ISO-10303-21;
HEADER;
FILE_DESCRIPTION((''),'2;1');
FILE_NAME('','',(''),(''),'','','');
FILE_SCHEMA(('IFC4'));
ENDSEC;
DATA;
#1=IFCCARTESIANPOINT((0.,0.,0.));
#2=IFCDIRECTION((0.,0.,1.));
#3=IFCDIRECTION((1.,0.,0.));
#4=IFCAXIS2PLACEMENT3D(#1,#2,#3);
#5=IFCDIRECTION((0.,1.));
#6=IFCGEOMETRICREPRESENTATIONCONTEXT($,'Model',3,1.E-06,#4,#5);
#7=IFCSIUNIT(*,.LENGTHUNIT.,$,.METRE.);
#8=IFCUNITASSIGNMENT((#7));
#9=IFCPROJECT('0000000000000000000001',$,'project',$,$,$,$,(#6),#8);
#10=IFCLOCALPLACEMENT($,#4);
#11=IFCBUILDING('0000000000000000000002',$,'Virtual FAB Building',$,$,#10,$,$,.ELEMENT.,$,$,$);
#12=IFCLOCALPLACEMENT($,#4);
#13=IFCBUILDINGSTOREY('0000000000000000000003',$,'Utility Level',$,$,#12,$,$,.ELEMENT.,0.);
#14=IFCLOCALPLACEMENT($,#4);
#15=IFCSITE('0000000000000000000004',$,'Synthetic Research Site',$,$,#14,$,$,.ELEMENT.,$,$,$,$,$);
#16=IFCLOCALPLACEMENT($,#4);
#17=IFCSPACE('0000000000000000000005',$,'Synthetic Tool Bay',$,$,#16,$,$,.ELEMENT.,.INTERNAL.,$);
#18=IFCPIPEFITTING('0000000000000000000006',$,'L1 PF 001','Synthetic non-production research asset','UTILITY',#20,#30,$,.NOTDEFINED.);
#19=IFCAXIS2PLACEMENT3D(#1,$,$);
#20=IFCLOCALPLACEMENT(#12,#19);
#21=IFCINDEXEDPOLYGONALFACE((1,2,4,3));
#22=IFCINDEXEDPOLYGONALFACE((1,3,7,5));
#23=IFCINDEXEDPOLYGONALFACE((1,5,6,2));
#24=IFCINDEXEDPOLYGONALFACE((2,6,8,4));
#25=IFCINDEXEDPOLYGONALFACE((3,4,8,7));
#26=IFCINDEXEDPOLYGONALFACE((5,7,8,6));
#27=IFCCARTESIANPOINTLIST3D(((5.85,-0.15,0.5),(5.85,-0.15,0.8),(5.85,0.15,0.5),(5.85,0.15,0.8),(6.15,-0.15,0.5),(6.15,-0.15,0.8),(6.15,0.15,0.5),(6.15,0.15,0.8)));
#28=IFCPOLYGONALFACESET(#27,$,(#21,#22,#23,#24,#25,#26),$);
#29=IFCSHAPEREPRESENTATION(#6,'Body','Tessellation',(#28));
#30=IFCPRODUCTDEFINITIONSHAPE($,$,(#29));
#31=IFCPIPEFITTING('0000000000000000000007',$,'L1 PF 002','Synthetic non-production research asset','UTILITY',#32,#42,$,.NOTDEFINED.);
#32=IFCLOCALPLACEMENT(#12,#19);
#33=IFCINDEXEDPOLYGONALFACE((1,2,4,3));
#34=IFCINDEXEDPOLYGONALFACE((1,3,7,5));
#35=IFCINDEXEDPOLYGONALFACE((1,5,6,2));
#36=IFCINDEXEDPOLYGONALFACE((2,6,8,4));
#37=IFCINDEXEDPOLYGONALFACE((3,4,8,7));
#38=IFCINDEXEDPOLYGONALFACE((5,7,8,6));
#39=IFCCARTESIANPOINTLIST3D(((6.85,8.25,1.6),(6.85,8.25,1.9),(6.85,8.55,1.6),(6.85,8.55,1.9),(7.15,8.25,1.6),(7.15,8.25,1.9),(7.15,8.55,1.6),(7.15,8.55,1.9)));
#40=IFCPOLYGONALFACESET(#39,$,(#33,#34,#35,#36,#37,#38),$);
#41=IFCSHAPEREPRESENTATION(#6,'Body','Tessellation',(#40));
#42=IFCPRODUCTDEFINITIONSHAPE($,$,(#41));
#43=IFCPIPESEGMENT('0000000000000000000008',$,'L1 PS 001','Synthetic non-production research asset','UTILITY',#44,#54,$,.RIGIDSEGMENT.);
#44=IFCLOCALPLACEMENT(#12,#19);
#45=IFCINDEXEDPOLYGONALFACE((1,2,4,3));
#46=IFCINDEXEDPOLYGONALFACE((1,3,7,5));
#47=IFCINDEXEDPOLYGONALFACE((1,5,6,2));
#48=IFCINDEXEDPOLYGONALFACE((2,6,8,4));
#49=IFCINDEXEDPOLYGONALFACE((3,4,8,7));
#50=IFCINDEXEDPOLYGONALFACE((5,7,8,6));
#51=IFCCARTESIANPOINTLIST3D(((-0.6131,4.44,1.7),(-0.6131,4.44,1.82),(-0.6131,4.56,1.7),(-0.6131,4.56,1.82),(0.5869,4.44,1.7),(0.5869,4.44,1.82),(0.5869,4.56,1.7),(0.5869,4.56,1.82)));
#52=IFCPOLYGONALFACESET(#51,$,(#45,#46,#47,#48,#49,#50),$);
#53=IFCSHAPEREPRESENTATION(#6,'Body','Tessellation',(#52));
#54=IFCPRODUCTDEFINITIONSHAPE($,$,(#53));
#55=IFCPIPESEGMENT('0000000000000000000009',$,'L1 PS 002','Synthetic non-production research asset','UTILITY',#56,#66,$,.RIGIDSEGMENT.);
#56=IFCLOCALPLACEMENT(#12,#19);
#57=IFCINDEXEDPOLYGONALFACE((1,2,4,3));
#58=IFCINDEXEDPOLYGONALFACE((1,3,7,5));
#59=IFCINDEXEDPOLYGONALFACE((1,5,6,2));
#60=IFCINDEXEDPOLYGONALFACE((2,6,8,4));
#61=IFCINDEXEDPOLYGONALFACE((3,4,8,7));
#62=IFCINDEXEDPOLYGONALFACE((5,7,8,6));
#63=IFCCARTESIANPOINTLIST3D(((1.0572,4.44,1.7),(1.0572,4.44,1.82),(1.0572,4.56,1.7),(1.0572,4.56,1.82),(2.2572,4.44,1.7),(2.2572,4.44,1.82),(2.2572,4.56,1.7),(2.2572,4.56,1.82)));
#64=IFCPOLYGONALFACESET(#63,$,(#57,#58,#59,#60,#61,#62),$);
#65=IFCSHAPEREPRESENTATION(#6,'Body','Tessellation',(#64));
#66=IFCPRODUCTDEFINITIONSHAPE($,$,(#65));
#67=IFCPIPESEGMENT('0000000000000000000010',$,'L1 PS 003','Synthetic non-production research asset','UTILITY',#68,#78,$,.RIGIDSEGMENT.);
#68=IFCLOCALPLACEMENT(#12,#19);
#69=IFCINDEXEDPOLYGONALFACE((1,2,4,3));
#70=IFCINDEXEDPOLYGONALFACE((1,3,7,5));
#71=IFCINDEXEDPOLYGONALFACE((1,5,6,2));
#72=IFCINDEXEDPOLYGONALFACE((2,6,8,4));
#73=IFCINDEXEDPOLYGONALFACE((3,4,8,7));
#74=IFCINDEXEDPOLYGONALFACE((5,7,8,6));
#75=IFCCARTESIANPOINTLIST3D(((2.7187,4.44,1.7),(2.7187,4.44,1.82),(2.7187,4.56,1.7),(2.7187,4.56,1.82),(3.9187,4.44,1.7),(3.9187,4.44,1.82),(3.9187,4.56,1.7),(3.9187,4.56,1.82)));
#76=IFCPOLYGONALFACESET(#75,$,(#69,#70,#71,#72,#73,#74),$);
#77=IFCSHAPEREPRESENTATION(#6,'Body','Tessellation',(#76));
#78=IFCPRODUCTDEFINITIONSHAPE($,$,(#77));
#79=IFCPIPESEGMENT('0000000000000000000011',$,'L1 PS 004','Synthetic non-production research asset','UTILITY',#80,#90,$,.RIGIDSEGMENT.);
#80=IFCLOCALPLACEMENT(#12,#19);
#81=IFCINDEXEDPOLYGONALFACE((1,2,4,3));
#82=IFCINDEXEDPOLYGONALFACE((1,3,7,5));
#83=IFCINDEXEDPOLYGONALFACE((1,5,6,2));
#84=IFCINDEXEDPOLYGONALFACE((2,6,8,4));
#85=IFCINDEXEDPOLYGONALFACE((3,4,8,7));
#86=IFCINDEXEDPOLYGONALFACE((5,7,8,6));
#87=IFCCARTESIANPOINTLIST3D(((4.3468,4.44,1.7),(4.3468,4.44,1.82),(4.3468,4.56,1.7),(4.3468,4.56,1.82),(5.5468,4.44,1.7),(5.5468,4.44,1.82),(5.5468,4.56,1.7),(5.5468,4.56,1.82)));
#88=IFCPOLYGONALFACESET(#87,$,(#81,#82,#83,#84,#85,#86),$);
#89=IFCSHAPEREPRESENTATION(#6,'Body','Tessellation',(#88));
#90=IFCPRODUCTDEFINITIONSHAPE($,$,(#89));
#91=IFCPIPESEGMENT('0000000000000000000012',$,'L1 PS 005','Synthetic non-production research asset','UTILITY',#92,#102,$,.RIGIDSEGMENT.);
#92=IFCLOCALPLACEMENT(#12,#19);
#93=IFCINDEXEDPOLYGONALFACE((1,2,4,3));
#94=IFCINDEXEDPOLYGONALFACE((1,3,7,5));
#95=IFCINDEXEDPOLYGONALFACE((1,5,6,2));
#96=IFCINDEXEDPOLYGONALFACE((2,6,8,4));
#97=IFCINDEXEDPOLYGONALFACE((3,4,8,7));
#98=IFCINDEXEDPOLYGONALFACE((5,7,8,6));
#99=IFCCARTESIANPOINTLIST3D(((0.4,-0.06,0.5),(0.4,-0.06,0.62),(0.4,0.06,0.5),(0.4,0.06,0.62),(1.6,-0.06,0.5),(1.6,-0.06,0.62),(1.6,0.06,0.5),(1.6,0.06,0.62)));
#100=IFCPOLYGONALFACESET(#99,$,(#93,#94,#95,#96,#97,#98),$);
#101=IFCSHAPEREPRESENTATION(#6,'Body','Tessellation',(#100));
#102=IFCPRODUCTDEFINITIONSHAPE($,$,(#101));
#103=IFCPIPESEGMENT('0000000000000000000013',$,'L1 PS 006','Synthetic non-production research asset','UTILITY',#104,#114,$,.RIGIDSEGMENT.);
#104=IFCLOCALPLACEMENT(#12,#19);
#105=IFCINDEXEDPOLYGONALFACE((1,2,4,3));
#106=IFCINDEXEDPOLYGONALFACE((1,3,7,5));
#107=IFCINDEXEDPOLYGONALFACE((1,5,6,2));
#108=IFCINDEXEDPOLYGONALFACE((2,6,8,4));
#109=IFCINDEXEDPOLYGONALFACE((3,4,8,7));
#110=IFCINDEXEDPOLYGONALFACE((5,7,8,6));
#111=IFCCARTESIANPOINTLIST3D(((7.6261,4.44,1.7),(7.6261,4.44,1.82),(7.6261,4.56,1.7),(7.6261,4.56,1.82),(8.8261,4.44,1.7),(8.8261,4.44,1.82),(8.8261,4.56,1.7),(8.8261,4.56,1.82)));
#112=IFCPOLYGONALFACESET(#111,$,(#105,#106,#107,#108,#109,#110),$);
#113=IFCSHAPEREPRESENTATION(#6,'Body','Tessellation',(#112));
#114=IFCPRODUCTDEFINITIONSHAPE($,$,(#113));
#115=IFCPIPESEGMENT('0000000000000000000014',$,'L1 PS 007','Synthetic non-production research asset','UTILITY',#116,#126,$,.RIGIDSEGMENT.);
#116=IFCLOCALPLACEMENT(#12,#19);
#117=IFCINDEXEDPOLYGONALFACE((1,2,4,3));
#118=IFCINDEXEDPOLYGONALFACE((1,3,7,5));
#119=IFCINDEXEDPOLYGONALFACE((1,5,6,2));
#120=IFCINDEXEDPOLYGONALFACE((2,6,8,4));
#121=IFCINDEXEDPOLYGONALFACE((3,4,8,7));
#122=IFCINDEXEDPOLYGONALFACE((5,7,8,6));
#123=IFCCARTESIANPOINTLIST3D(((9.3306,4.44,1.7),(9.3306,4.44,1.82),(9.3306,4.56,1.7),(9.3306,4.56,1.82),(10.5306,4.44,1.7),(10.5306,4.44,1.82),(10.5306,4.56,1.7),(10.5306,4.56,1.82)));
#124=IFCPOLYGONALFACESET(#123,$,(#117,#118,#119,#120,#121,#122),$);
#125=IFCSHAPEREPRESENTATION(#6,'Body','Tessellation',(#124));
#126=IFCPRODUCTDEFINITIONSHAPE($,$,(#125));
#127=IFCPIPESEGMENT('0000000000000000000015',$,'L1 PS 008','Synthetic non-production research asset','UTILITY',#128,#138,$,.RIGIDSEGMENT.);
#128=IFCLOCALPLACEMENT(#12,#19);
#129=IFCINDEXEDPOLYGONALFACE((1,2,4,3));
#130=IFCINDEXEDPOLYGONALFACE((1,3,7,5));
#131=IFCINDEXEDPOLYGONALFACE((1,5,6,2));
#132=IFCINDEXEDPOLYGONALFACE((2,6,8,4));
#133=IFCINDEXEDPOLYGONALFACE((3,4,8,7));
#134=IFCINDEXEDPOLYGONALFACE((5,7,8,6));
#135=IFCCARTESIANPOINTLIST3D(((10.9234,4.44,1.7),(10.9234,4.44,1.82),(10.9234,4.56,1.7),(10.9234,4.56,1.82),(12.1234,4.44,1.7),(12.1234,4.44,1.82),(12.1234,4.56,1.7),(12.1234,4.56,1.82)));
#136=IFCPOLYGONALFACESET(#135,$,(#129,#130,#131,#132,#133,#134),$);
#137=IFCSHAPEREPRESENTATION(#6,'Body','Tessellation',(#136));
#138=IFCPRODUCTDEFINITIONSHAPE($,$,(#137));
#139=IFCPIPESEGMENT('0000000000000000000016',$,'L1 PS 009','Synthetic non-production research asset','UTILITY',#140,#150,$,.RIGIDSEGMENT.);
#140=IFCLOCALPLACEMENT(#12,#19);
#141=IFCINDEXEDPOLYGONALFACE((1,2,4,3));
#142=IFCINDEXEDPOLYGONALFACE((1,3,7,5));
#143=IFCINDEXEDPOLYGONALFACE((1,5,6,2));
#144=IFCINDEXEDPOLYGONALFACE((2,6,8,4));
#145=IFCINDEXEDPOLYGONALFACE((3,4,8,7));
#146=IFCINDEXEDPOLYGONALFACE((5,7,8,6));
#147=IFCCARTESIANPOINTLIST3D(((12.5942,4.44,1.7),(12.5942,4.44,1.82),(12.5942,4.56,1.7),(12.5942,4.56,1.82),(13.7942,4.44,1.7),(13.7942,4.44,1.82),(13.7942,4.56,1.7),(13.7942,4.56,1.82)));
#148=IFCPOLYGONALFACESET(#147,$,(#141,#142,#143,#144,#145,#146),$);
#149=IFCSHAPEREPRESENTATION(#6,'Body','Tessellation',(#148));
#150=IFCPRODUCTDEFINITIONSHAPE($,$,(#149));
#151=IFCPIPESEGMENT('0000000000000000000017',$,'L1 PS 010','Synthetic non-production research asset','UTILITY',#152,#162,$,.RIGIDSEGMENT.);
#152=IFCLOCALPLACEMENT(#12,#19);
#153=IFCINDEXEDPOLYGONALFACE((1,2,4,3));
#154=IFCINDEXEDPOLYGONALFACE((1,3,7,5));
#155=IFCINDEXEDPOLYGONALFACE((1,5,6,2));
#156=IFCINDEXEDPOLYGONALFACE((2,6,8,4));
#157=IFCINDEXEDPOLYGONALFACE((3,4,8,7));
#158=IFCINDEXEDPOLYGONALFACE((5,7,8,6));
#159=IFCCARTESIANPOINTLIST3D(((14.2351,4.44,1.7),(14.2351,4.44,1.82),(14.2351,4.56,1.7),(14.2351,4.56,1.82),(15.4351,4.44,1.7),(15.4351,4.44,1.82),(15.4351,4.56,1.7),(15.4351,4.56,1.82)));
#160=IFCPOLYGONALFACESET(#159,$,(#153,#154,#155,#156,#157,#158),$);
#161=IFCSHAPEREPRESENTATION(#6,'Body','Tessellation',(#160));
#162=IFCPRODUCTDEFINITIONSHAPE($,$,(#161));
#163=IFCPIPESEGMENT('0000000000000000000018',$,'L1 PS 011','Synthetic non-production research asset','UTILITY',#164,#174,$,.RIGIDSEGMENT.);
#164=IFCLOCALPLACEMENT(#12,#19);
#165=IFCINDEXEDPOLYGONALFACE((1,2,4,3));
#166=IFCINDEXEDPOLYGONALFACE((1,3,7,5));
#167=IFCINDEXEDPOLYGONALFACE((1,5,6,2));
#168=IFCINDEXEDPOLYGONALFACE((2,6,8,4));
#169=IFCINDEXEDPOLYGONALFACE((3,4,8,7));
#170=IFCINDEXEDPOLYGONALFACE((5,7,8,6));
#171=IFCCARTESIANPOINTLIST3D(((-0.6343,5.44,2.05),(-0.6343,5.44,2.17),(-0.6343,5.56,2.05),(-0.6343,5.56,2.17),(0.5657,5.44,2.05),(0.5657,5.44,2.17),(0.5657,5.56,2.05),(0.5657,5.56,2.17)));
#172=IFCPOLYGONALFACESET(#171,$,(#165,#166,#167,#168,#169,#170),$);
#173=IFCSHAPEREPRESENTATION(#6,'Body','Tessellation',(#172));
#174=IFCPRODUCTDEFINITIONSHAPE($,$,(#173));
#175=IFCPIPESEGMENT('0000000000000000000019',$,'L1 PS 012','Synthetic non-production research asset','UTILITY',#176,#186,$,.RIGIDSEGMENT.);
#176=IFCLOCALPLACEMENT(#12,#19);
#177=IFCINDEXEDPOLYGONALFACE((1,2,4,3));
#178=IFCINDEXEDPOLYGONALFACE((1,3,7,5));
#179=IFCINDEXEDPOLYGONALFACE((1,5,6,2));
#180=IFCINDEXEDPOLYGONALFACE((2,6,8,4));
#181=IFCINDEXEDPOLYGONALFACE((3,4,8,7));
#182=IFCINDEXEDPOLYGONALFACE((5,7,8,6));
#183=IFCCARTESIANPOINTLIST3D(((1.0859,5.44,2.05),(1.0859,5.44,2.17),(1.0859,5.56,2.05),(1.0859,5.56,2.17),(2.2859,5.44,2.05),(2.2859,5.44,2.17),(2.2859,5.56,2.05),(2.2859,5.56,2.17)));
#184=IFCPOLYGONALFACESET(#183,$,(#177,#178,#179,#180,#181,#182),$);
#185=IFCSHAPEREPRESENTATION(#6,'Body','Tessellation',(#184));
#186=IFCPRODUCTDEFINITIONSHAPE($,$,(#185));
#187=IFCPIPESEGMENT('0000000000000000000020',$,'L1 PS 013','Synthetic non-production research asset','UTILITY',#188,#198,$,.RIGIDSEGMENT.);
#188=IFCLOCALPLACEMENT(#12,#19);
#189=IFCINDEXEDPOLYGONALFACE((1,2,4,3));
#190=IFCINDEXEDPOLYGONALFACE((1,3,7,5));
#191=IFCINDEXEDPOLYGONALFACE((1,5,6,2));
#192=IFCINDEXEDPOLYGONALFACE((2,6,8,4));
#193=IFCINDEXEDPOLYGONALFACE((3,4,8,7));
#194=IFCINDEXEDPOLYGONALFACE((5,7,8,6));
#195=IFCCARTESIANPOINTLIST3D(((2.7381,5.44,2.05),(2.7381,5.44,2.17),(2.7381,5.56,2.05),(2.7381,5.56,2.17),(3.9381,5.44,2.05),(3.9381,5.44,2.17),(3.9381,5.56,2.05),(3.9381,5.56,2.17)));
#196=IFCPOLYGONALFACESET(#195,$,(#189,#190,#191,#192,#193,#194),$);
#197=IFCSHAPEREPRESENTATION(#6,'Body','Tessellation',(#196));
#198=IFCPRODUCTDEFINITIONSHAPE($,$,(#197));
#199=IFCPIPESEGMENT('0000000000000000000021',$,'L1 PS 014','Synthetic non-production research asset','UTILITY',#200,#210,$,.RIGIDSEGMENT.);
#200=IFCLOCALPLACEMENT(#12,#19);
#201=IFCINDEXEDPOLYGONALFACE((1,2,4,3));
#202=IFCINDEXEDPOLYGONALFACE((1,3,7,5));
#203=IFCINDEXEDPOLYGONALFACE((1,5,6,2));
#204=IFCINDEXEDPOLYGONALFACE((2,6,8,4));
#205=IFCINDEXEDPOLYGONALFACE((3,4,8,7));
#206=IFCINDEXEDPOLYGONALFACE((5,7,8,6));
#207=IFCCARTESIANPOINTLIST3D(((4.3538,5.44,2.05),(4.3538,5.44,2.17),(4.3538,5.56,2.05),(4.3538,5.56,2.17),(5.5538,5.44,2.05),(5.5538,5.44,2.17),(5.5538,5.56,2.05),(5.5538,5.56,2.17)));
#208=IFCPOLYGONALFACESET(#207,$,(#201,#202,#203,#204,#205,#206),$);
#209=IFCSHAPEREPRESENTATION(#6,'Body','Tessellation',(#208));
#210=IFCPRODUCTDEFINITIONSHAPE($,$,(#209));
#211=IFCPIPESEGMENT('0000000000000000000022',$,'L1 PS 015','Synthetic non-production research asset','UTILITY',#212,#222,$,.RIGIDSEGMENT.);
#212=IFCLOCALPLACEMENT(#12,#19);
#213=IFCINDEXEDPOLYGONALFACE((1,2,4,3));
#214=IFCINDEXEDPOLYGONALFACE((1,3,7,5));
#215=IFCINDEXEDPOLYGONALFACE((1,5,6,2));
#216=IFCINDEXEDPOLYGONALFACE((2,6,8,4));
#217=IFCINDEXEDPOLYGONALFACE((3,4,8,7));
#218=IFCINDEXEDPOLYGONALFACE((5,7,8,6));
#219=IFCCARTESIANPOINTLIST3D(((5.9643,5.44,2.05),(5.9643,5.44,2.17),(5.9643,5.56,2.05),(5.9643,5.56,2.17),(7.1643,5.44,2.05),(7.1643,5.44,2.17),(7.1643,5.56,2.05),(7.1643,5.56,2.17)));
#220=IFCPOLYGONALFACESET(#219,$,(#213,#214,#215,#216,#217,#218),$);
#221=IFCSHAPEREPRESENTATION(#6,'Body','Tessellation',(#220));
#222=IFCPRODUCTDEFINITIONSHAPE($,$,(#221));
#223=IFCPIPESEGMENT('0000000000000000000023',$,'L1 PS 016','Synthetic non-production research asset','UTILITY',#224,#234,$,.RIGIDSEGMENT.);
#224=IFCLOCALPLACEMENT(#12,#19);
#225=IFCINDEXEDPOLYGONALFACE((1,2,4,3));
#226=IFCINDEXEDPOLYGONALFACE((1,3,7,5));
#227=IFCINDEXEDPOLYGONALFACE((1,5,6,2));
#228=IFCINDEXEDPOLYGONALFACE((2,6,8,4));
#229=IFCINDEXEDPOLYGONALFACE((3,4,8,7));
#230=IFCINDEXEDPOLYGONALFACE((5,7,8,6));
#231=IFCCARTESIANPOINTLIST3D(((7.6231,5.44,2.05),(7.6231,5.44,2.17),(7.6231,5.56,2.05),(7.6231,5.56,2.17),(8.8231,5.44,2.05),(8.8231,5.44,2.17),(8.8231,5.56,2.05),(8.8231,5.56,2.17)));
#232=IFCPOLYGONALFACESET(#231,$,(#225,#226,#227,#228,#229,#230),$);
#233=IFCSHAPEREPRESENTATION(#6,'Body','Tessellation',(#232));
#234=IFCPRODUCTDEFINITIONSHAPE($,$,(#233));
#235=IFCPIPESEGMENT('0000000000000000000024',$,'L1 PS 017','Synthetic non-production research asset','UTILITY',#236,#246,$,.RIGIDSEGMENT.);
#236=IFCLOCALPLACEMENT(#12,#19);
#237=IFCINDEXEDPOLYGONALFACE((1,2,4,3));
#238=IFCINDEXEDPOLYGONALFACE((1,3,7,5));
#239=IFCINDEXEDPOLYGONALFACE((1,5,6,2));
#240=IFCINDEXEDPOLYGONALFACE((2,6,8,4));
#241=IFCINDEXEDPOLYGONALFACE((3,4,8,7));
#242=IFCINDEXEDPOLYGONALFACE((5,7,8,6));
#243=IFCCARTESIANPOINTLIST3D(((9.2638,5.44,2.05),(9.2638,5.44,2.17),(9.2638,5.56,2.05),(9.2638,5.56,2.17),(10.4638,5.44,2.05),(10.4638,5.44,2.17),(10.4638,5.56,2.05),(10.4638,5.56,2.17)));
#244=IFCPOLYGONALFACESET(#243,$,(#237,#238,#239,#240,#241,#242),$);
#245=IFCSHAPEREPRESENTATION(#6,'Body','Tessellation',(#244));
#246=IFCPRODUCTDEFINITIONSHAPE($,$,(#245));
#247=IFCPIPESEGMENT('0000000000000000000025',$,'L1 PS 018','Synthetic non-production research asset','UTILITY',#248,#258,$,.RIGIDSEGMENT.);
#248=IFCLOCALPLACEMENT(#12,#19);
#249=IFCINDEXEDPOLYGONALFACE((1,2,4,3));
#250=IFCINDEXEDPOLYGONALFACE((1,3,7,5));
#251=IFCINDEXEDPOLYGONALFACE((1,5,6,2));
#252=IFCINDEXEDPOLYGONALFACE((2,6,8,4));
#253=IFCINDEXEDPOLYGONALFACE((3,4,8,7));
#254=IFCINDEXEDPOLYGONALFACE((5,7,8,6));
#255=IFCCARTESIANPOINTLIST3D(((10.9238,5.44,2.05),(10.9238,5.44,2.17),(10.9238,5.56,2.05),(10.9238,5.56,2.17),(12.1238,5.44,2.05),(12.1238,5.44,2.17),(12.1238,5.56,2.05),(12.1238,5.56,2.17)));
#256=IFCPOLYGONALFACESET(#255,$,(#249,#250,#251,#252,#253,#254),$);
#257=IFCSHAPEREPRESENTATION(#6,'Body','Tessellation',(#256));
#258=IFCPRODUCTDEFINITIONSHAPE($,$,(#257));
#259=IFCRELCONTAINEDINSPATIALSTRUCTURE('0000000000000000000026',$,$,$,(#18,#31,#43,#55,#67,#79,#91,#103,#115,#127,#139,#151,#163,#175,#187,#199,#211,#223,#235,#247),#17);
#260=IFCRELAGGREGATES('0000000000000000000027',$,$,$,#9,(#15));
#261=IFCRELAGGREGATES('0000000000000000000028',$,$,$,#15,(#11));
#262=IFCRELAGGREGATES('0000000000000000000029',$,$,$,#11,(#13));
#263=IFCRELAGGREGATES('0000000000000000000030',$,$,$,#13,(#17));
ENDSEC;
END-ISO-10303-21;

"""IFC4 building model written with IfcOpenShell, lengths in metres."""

from ifc_helpers import new_model, si_unit, direction, frame, origin_with_axes, origin_2d_with_axis, place, context, project, spatial, rectangle, extrude, element, save


model = new_model("IFC4")

# Units and contexts
model_context = context("Model", 3, precision=1e-06, world=origin_with_axes(), true_north=direction((0.0, 1.0)))
ifc_project = project(units=[si_unit("LENGTHUNIT", "METRE")], contexts=[model_context])

# Site, building, storey, space
site_placement = place(None, origin_with_axes())
site = spatial("IfcSite", under=ifc_project, at=site_placement, Name="Synthetic Research Site", CompositionType="ELEMENT")
building_placement = place(None, origin_with_axes())
building = spatial("IfcBuilding", under=site, at=building_placement, Name="Virtual FAB Building", CompositionType="ELEMENT")
storey_placement = place(None, origin_with_axes())
storey = spatial("IfcBuildingStorey", under=building, at=storey_placement, Name="Utility Level", CompositionType="ELEMENT", Elevation=0.0)
space_placement = place(None, origin_with_axes())
space = spatial("IfcSpace", under=storey, at=space_placement, Name="Synthetic Tool Bay", CompositionType="ELEMENT", PredefinedType="INTERNAL")

# Pipe fittings
for number, where, z_axis, x_axis, name in (
    (1, (6.0, 0.0, 0.5), (0.0, 0.0, 1.0), (1.0, 0.0, 0.0), "L1 PF 001"),
    (2, (7.0, 8.4, 1.6), (0.0, 0.0, 1.0), (1.0, 0.0, 0.0), "L1 PF 002"),
):
    element("IfcPipeFitting", number, at=place(None, frame(where, z_axis=z_axis, x_axis=x_axis)), inside=space, Name=name, Description="Synthetic non-production research asset", ObjectType="UTILITY", PredefinedType="NOTDEFINED", context=model_context, shape_type="SweptSolid", body=[
        extrude(rectangle(XDim=0.3, YDim=0.3, at=origin_2d_with_axis()), origin_with_axes(), (0.0, 0.0, 1.0), 0.3),
    ])

# Pipe segments
for number, where, z_axis, x_axis, name in (
    (3, (-0.0131, 4.5, 1.7), (0.0, 0.0, 1.0), (1.0, 0.0, 0.0), "L1 PS 001"),
    (4, (1.6572, 4.5, 1.7), (0.0, 0.0, 1.0), (1.0, 0.0, 0.0), "L1 PS 002"),
    (5, (3.3187, 4.5, 1.7), (0.0, 0.0, 1.0), (1.0, 0.0, 0.0), "L1 PS 003"),
    (6, (4.9468, 4.5, 1.7), (0.0, 0.0, 1.0), (1.0, 0.0, 0.0), "L1 PS 004"),
    (7, (1.0, 0.0, 0.5), (0.0, 0.0, 1.0), (1.0, 0.0, 0.0), "L1 PS 005"),
    (8, (8.2261, 4.5, 1.7), (0.0, 0.0, 1.0), (1.0, 0.0, 0.0), "L1 PS 006"),
    (9, (9.9306, 4.5, 1.7), (0.0, 0.0, 1.0), (1.0, 0.0, 0.0), "L1 PS 007"),
    (10, (11.5234, 4.5, 1.7), (0.0, 0.0, 1.0), (1.0, 0.0, 0.0), "L1 PS 008"),
    (11, (13.1942, 4.5, 1.7), (0.0, 0.0, 1.0), (1.0, 0.0, 0.0), "L1 PS 009"),
    (12, (14.8351, 4.5, 1.7), (0.0, 0.0, 1.0), (1.0, 0.0, 0.0), "L1 PS 010"),
    (13, (-0.0343, 5.5, 2.05), (0.0, 0.0, 1.0), (1.0, 0.0, 0.0), "L1 PS 011"),
    (14, (1.6859, 5.5, 2.05), (0.0, 0.0, 1.0), (1.0, 0.0, 0.0), "L1 PS 012"),
    (15, (3.3381, 5.5, 2.05), (0.0, 0.0, 1.0), (1.0, 0.0, 0.0), "L1 PS 013"),
    (16, (4.9538, 5.5, 2.05), (0.0, 0.0, 1.0), (1.0, 0.0, 0.0), "L1 PS 014"),
    (17, (6.5643, 5.5, 2.05), (0.0, 0.0, 1.0), (1.0, 0.0, 0.0), "L1 PS 015"),
    (18, (8.2231, 5.5, 2.05), (0.0, 0.0, 1.0), (1.0, 0.0, 0.0), "L1 PS 016"),
    (19, (9.8638, 5.5, 2.05), (0.0, 0.0, 1.0), (1.0, 0.0, 0.0), "L1 PS 017"),
    (20, (11.5238, 5.5, 2.05), (0.0, 0.0, 1.0), (1.0, 0.0, 0.0), "L1 PS 018"),
):
    element("IfcPipeSegment", number, at=place(None, frame(where, z_axis=z_axis, x_axis=x_axis)), inside=space, Name=name, Description="Synthetic non-production research asset", ObjectType="UTILITY", PredefinedType="RIGIDSEGMENT", context=model_context, shape_type="SweptSolid", body=[
        extrude(rectangle(XDim=1.2, YDim=0.12, at=origin_2d_with_axis()), origin_with_axes(), (0.0, 0.0, 1.0), 0.12),
    ])

save(model, "model.ifc")
